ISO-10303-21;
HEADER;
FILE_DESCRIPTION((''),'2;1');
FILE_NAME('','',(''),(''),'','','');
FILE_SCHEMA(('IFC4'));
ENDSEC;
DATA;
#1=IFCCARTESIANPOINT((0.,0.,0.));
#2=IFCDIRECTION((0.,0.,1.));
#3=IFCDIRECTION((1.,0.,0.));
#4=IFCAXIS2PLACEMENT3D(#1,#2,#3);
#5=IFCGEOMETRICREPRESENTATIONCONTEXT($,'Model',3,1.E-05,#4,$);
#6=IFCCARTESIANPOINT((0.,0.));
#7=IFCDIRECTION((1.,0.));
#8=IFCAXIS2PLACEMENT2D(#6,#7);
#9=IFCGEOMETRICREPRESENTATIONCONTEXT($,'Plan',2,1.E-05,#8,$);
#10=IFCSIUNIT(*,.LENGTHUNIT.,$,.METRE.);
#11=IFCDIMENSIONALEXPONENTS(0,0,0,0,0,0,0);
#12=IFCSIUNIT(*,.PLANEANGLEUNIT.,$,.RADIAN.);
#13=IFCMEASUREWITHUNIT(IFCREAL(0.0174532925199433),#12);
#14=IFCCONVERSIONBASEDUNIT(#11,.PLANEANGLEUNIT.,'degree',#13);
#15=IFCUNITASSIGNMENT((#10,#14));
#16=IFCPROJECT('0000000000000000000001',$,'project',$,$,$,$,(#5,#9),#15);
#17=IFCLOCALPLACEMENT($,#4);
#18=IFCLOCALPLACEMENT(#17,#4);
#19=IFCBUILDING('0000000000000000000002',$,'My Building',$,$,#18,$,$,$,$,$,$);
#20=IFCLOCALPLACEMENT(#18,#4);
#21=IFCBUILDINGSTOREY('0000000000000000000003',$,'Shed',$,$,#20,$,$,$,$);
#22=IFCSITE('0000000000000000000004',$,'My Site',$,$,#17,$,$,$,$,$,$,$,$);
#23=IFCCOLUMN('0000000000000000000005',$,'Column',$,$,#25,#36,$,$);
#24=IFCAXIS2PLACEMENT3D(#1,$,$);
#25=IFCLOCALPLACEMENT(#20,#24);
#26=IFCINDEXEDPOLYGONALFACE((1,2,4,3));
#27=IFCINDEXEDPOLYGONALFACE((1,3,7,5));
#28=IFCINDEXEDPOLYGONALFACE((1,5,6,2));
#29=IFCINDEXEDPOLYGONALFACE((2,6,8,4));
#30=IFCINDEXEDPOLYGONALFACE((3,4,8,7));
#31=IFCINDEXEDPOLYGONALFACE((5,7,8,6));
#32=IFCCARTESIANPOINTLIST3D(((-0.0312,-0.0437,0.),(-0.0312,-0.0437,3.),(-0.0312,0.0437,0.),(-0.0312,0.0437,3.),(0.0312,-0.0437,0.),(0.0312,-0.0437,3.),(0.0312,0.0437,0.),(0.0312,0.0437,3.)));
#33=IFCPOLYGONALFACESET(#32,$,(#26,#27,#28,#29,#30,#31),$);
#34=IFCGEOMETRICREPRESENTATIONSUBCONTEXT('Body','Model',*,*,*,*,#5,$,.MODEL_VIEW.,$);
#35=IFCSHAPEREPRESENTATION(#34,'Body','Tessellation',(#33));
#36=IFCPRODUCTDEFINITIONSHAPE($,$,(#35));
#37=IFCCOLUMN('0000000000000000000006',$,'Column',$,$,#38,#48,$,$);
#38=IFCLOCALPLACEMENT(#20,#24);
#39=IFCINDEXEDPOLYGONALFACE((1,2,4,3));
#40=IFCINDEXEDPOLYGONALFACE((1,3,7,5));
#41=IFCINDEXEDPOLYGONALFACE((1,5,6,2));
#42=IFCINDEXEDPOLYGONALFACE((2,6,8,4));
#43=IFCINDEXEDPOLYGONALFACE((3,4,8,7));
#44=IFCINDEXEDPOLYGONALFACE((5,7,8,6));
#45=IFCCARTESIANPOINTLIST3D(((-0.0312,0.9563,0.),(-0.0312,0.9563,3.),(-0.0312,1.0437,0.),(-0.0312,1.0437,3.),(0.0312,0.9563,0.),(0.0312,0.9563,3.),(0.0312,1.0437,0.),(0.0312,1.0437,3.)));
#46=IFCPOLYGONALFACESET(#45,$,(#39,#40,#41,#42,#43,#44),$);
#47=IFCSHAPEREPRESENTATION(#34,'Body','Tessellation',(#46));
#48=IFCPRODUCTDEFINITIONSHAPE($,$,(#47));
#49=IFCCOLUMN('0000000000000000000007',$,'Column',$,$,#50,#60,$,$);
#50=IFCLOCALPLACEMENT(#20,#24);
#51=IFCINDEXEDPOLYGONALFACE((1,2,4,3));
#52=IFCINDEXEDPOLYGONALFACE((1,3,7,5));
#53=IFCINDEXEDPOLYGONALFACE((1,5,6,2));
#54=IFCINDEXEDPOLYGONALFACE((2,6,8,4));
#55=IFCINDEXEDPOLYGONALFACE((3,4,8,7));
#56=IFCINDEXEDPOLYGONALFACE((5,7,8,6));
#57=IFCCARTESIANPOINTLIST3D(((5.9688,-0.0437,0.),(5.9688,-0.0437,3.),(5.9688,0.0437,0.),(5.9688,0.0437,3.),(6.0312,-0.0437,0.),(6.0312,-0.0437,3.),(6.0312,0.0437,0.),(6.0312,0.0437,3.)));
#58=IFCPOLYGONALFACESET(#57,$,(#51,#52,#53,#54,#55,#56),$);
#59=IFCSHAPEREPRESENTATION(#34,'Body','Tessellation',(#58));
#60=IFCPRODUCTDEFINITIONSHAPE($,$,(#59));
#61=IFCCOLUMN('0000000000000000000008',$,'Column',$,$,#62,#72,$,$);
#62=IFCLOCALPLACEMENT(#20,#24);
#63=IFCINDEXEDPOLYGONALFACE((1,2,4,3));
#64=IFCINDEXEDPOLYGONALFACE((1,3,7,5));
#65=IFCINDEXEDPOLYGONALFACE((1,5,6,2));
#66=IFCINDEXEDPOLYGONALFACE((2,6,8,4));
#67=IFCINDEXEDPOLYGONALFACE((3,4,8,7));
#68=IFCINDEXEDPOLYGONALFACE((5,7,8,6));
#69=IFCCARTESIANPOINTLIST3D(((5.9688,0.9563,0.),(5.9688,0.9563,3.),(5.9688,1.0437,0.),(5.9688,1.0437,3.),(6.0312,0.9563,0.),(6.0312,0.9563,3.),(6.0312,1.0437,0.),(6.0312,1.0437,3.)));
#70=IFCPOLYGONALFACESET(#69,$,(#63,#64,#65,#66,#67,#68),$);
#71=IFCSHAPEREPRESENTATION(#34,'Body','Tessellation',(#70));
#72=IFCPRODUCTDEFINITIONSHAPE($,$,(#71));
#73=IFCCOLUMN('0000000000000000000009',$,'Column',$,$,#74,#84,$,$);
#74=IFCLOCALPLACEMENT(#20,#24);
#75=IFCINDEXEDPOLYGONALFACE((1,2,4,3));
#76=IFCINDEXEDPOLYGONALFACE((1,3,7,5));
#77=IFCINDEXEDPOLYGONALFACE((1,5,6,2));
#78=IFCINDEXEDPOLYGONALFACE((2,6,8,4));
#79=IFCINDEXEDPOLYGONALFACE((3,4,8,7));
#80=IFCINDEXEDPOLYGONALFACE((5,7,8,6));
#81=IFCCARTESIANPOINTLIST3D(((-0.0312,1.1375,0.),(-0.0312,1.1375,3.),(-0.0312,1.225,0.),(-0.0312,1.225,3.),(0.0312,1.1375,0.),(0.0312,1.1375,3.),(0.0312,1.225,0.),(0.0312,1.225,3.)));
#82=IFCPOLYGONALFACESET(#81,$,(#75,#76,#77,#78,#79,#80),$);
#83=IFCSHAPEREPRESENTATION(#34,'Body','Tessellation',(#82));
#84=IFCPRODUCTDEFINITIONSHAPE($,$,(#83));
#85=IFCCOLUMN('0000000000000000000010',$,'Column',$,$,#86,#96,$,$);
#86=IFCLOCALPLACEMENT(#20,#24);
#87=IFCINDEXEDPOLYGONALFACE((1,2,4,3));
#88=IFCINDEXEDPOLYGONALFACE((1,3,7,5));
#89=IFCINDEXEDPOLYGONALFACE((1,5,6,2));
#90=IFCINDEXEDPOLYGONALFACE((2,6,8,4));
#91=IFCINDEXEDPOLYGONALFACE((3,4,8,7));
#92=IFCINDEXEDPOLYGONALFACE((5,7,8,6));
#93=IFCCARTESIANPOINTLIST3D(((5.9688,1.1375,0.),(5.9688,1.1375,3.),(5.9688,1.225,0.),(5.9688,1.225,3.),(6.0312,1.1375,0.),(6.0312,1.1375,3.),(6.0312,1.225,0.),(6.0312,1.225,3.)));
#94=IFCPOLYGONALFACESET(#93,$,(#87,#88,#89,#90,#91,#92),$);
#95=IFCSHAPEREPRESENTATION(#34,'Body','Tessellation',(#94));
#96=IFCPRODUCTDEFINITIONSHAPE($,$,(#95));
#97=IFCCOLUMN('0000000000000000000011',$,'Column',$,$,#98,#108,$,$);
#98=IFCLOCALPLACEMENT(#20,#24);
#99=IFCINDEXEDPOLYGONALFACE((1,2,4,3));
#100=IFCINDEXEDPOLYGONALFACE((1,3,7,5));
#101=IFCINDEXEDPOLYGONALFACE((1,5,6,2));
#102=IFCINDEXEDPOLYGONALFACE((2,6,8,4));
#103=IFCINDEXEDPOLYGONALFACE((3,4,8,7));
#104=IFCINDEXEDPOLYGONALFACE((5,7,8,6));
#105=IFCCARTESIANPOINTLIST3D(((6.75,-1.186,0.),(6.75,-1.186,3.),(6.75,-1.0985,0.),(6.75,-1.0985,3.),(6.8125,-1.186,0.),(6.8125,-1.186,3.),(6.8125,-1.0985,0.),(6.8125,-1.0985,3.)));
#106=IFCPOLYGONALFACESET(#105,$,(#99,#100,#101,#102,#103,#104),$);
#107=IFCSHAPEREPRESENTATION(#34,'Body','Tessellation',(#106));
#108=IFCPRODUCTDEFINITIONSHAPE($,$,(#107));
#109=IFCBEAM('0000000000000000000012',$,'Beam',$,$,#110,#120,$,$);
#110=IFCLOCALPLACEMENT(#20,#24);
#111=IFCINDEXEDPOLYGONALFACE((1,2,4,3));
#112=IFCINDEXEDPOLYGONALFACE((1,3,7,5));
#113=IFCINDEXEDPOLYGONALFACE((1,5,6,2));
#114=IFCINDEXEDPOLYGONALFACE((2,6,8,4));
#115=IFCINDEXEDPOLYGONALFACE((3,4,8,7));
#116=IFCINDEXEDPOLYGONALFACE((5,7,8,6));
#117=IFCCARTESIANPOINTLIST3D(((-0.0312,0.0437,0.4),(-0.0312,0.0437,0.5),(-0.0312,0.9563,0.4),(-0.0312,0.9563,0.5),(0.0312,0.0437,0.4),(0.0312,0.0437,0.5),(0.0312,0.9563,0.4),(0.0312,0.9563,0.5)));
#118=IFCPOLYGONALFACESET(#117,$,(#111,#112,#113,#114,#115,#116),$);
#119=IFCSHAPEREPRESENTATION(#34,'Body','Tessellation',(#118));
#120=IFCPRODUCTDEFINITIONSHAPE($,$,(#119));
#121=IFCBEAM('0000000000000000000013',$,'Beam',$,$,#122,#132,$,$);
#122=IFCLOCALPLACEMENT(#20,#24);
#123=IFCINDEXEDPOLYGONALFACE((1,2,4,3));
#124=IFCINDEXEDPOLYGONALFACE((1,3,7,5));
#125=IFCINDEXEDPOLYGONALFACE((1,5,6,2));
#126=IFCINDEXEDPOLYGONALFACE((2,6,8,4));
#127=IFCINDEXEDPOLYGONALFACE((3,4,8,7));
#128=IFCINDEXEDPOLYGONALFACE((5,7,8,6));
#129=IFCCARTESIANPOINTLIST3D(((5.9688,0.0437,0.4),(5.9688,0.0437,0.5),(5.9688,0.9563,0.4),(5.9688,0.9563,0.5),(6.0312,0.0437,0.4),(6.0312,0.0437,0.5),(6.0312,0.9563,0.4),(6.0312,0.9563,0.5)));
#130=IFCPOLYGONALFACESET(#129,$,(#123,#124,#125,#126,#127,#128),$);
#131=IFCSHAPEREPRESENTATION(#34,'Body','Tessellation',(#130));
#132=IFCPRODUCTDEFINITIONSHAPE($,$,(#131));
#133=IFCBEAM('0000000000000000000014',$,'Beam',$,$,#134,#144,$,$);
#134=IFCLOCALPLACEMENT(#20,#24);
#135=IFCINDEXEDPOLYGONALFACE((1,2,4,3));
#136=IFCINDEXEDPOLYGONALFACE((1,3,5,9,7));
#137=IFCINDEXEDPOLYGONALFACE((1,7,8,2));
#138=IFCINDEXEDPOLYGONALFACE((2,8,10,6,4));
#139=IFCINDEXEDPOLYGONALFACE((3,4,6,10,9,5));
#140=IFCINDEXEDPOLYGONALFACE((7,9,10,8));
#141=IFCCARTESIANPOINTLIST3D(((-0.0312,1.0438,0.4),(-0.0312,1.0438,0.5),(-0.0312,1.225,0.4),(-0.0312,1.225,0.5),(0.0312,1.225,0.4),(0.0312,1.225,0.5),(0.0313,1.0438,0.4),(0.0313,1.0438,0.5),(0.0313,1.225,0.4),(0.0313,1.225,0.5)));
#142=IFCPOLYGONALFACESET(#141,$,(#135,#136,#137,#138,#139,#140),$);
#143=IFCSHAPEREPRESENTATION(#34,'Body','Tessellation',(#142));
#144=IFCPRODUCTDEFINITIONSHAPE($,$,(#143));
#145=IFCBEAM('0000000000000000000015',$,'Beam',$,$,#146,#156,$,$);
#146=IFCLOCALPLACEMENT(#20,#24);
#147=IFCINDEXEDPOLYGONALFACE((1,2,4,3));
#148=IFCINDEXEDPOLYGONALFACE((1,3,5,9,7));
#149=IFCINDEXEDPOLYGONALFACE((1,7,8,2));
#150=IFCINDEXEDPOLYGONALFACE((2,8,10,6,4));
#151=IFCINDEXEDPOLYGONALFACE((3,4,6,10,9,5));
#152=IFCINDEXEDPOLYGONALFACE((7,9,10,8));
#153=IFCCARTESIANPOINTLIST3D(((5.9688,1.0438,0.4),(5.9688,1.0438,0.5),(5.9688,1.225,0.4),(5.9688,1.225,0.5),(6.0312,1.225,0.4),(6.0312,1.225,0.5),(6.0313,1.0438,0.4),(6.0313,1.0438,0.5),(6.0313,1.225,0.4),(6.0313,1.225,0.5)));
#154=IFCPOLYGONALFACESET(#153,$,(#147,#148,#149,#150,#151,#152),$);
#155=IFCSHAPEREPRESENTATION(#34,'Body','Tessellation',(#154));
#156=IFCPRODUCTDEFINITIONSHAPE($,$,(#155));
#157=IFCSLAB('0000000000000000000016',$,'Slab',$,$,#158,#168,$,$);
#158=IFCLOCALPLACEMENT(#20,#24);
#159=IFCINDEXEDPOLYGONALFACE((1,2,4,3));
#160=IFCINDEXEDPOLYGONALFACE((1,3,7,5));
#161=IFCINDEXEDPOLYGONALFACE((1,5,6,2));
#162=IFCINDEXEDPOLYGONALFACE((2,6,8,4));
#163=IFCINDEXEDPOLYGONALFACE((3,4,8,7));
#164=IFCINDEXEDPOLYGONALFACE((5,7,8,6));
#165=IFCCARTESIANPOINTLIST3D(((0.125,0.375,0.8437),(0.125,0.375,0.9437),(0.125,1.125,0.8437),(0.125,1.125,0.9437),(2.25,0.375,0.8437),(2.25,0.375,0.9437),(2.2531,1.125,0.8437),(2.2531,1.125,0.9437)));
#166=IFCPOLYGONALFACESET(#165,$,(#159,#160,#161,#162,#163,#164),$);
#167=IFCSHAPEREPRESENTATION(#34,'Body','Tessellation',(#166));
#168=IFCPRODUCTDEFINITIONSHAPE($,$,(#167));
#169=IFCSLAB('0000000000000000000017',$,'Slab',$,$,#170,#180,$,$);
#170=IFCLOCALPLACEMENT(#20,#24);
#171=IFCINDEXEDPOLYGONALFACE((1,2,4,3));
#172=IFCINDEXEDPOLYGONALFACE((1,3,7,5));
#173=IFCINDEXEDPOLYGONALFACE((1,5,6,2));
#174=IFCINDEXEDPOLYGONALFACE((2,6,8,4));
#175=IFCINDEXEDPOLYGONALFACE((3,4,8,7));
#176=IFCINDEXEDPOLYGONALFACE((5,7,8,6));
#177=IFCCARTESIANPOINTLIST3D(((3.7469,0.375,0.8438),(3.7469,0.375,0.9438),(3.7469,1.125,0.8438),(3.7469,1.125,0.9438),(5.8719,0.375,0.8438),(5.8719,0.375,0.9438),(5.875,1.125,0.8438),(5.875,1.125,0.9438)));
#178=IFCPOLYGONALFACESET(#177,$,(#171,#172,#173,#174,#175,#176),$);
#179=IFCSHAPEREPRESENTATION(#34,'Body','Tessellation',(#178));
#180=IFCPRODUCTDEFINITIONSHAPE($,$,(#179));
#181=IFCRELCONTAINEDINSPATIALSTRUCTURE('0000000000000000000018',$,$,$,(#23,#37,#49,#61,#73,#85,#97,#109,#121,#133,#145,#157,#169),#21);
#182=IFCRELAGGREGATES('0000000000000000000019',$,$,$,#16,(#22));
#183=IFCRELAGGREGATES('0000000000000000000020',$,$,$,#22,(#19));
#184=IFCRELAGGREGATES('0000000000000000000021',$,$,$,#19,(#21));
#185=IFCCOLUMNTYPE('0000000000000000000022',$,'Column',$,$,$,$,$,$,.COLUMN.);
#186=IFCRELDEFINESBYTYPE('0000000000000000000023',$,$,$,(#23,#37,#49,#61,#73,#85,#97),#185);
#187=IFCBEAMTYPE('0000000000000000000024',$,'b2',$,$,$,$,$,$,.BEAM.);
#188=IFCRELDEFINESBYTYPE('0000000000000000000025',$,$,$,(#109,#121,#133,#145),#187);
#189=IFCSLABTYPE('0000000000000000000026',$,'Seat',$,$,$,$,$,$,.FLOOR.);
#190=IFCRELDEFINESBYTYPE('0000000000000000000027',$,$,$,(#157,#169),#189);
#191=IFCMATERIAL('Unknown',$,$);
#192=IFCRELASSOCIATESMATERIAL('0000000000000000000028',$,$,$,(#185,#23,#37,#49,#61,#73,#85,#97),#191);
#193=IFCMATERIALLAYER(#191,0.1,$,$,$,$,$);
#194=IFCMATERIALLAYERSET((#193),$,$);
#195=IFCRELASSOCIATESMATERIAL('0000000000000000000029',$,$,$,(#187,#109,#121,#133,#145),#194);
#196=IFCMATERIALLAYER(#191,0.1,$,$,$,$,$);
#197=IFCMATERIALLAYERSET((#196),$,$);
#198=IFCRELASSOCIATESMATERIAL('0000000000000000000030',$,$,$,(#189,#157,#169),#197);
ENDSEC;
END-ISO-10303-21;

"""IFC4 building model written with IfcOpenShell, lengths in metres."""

from ifc_helpers import new_model, entity, si_unit, converted_unit, frame, origin_with_axes, origin_2d_with_axis, place, context, subcontext, project, spatial, indexed_curve, outline, extrude, material, layer, layer_set, layer_usage, material_profile, profile_set, profile_usage, type_object, element, save


model = new_model("IFC4")

# Units and contexts
model_context = context("Model", 3, precision=1e-05, world=origin_with_axes())
plan_context = context("Plan", 2, precision=1e-05, world=origin_2d_with_axis())
body_context_1 = subcontext(model_context, "Body", "Model", "MODEL_VIEW")
ifc_project = project(units=[si_unit("LENGTHUNIT", "METRE"), converted_unit("PLANEANGLEUNIT", "degree", entity("IfcReal", 0.0174532925199433), si_unit("PLANEANGLEUNIT", "RADIAN"), dimensions=[0, 0, 0, 0, 0, 0, 0])], contexts=[model_context, plan_context])

# Site, building, storey
site_placement = place(None, origin_with_axes())
site = spatial("IfcSite", under=ifc_project, at=site_placement, Name="My Site")
building_placement = place(site_placement, origin_with_axes())
building = spatial("IfcBuilding", under=site, at=building_placement, Name="My Building")
storey_placement = place(building_placement, origin_with_axes())
storey = spatial("IfcBuildingStorey", under=building, at=storey_placement, Name="Shed")

# Columns
ifc_material = material(Name="Unknown")
ifc_material_profile = material_profile(ifc_material, outline(indexed_curve([(-0.0312, 0.0437), (0.0312, 0.0437), (0.0312, -0.0437), (-0.0312, -0.0437), (-0.0312, 0.0437)])))
ifc_profile_set = profile_set([ifc_material_profile])
ifc_profile_usage_1 = profile_usage(ifc_profile_set, cardinal=5)
column_type = type_object("IfcColumnType", Name="Column", PredefinedType="COLUMN", material=ifc_profile_set)
column_1_placement = place(storey_placement, origin_with_axes())
element("IfcColumn", 1, at=column_1_placement, inside=storey, type_object=column_type, material=ifc_profile_usage_1, Name="Column", context=body_context_1, shape_type="SweptSolid", body=[
    extrude(outline(indexed_curve([(-0.0312, 0.0437), (0.0312, 0.0437), (0.0312, -0.0437), (-0.0312, -0.0437), (-0.0312, 0.0437)])), origin_with_axes(), (0.0, 0.0, 1.0), 3.0),
])
ifc_profile_usage_2 = profile_usage(ifc_profile_set, cardinal=5)
column_2_placement = place(storey_placement, frame((0.0, 1.0, 0.0), z_axis=(0.0, 0.0, 1.0), x_axis=(1.0, 0.0, 0.0)))
element("IfcColumn", 2, at=column_2_placement, inside=storey, type_object=column_type, material=ifc_profile_usage_2, Name="Column", context=body_context_1, shape_type="SweptSolid", body=[
    extrude(outline(indexed_curve([(-0.0312, 0.0437), (0.0312, 0.0437), (0.0312, -0.0437), (-0.0312, -0.0437), (-0.0312, 0.0437)])), origin_with_axes(), (0.0, 0.0, 1.0), 3.0),
])
ifc_profile_usage_3 = profile_usage(ifc_profile_set, cardinal=5)
column_3_placement = place(storey_placement, frame((6.0, 0.0, 0.0), z_axis=(0.0, 0.0, 1.0), x_axis=(1.0, 0.0, 0.0)))
element("IfcColumn", 3, at=column_3_placement, inside=storey, type_object=column_type, material=ifc_profile_usage_3, Name="Column", context=body_context_1, shape_type="SweptSolid", body=[
    extrude(outline(indexed_curve([(-0.0312, 0.0437), (0.0312, 0.0437), (0.0312, -0.0437), (-0.0312, -0.0437), (-0.0312, 0.0437)])), origin_with_axes(), (0.0, 0.0, 1.0), 3.0),
])
ifc_profile_usage_4 = profile_usage(ifc_profile_set, cardinal=5)
column_4_placement = place(storey_placement, frame((6.0, 1.0, 0.0), z_axis=(0.0, 0.0, 1.0), x_axis=(1.0, 0.0, 0.0)))
element("IfcColumn", 4, at=column_4_placement, inside=storey, type_object=column_type, material=ifc_profile_usage_4, Name="Column", context=body_context_1, shape_type="SweptSolid", body=[
    extrude(outline(indexed_curve([(-0.0312, 0.0437), (0.0312, 0.0437), (0.0312, -0.0437), (-0.0312, -0.0437), (-0.0312, 0.0437)])), origin_with_axes(), (0.0, 0.0, 1.0), 3.0),
])
ifc_profile_usage_5 = profile_usage(ifc_profile_set, cardinal=5)
column_5_placement = place(storey_placement, frame((0.0, 1.1812, 0.0), z_axis=(0.0, 0.0, 1.0), x_axis=(1.0, 0.0, 0.0)))
element("IfcColumn", 5, at=column_5_placement, inside=storey, type_object=column_type, material=ifc_profile_usage_5, Name="Column", context=body_context_1, shape_type="SweptSolid", body=[
    extrude(outline(indexed_curve([(-0.0312, 0.0437), (0.0312, 0.0437), (0.0312, -0.0437), (-0.0312, -0.0437), (-0.0312, 0.0437)])), origin_with_axes(), (0.0, 0.0, 1.0), 3.0),
])
ifc_profile_usage_6 = profile_usage(ifc_profile_set, cardinal=5)
column_6_placement = place(storey_placement, frame((6.0, 1.1812, 0.0), z_axis=(0.0, 0.0, 1.0), x_axis=(1.0, 0.0, 0.0)))
element("IfcColumn", 6, at=column_6_placement, inside=storey, type_object=column_type, material=ifc_profile_usage_6, Name="Column", context=body_context_1, shape_type="SweptSolid", body=[
    extrude(outline(indexed_curve([(-0.0312, 0.0437), (0.0312, 0.0437), (0.0312, -0.0437), (-0.0312, -0.0437), (-0.0312, 0.0437)])), origin_with_axes(), (0.0, 0.0, 1.0), 3.0),
])
ifc_profile_usage_7 = profile_usage(ifc_profile_set, cardinal=5)
column_7_placement = place(storey_placement, frame((6.7812, -1.1423, 0.0), z_axis=(0.0, 0.0, 1.0), x_axis=(1.0, 0.0, 0.0)))
element("IfcColumn", 7, at=column_7_placement, inside=storey, type_object=column_type, material=ifc_profile_usage_7, Name="Column", context=body_context_1, shape_type="SweptSolid", body=[
    extrude(outline(indexed_curve([(-0.0312, 0.0437), (0.0312, 0.0437), (0.0312, -0.0437), (-0.0312, -0.0437), (-0.0312, 0.0437)])), origin_with_axes(), (0.0, 0.0, 1.0), 3.0),
])

# Beams
ifc_layer_1 = layer(ifc_material, 0.1)
ifc_layer_set_1 = layer_set([ifc_layer_1])
ifc_layer_usage_1 = layer_usage(ifc_layer_set_1, "AXIS3", "POSITIVE", -0.1)
beam_type = type_object("IfcBeamType", Name="b2", PredefinedType="BEAM", material=ifc_layer_set_1)
beam_1_placement = place(storey_placement, frame((-0.0312, 0.9563, 0.5), z_axis=(0.0, 0.0, 1.0), x_axis=(1.0, 0.0, 0.0)))
element("IfcBeam", 8, at=beam_1_placement, inside=storey, type_object=beam_type, material=ifc_layer_usage_1, Name="Beam", context=body_context_1, shape_type="SweptSolid", body=[
    extrude(outline(indexed_curve([(0.0, 0.0), (0.0, -0.9125), (0.0625, -0.9125), (0.0625, 0.0), (0.0, 0.0)])), frame((0.0, 0.0, -0.1), z_axis=(0.0, 0.0, 1.0), x_axis=(1.0, 0.0, 0.0)), (0.0, 0.0, 1.0), 0.1),
])
ifc_layer_usage_2 = layer_usage(ifc_layer_set_1, "AXIS3", "POSITIVE", -0.1)
beam_2_placement = place(storey_placement, frame((5.9688, 0.9563, 0.5), z_axis=(0.0, 0.0, 1.0), x_axis=(1.0, 0.0, 0.0)))
element("IfcBeam", 9, at=beam_2_placement, inside=storey, type_object=beam_type, material=ifc_layer_usage_2, Name="Beam", context=body_context_1, shape_type="SweptSolid", body=[
    extrude(outline(indexed_curve([(0.0, 0.0), (0.0, -0.9125), (0.0625, -0.9125), (0.0625, 0.0), (0.0, 0.0)])), frame((0.0, 0.0, -0.1), z_axis=(0.0, 0.0, 1.0), x_axis=(1.0, 0.0, 0.0)), (0.0, 0.0, 1.0), 0.1),
])
ifc_layer_usage_3 = layer_usage(ifc_layer_set_1, "AXIS3", "POSITIVE", -0.1)
beam_3_placement = place(storey_placement, frame((-0.0312, 1.0438, 0.5), z_axis=(0.0, 0.0, 1.0), x_axis=(1.0, 0.0, 0.0)))
element("IfcBeam", 10, at=beam_3_placement, inside=storey, type_object=beam_type, material=ifc_layer_usage_3, Name="Beam", context=body_context_1, shape_type="SweptSolid", body=[
    extrude(outline(indexed_curve([(0.0, 0.0), (0.0, 0.1812), (0.0624, 0.1812), (0.0626, 0.1812), (0.0626, 0.0), (0.0, 0.0)])), frame((0.0, 0.0, -0.1), z_axis=(0.0, 0.0, 1.0), x_axis=(1.0, 0.0, 0.0)), (0.0, 0.0, 1.0), 0.1),
])
ifc_layer_usage_4 = layer_usage(ifc_layer_set_1, "AXIS3", "POSITIVE", -0.1)
beam_4_placement = place(storey_placement, frame((5.9688, 1.0438, 0.5), z_axis=(0.0, 0.0, 1.0), x_axis=(1.0, 0.0, 0.0)))
element("IfcBeam", 11, at=beam_4_placement, inside=storey, type_object=beam_type, material=ifc_layer_usage_4, Name="Beam", context=body_context_1, shape_type="SweptSolid", body=[
    extrude(outline(indexed_curve([(0.0, 0.0), (0.0, 0.1812), (0.0624, 0.1812), (0.0626, 0.1812), (0.0626, 0.0), (0.0, 0.0)])), frame((0.0, 0.0, -0.1), z_axis=(0.0, 0.0, 1.0), x_axis=(1.0, 0.0, 0.0)), (0.0, 0.0, 1.0), 0.1),
])

# Slabs
ifc_layer_2 = layer(ifc_material, 0.1)
ifc_layer_set_2 = layer_set([ifc_layer_2])
ifc_layer_usage_5 = layer_usage(ifc_layer_set_2, "AXIS3", "POSITIVE", -0.1)
slab_type_1 = type_object("IfcSlabType", Name="Seat", PredefinedType="FLOOR", material=ifc_layer_set_2)
slab_1_placement = place(storey_placement, frame((0.125, 1.125, 0.9437), z_axis=(0.0, 0.0, 1.0), x_axis=(1.0, 0.0, 0.0)))
element("IfcSlab", 12, at=slab_1_placement, inside=storey, type_object=slab_type_1, material=ifc_layer_usage_5, Name="Slab", context=body_context_1, shape_type="SweptSolid", body=[
    extrude(outline(indexed_curve([(0.0, 0.0), (0.0, -0.75), (2.125, -0.75), (2.1281, 0.0), (0.0, 0.0)])), frame((0.0, 0.0, -0.1), z_axis=(0.0, 0.0, 0.5), x_axis=(1.0, 0.0, 0.0)), (0.0, 0.0, 1.0), 0.1),
])
ifc_layer_usage_6 = layer_usage(ifc_layer_set_2, "AXIS3", "POSITIVE", -0.1)
slab_2_placement = place(storey_placement, frame((3.7469, 1.125, 0.9438), z_axis=(0.0, 0.0, 1.0), x_axis=(1.0, 0.0, 0.0)))
element("IfcSlab", 13, at=slab_2_placement, inside=storey, type_object=slab_type_1, material=ifc_layer_usage_6, Name="Slab", context=body_context_1, shape_type="SweptSolid", body=[
    extrude(outline(indexed_curve([(0.0, 0.0), (0.0, -0.75), (2.125, -0.75), (2.1281, 0.0), (0.0, 0.0)])), frame((0.0, 0.0, -0.1), z_axis=(0.0, 0.0, 0.5), x_axis=(1.0, 0.0, 0.0)), (0.0, 0.0, 1.0), 0.1),
])

save(model, "model.ifc")
